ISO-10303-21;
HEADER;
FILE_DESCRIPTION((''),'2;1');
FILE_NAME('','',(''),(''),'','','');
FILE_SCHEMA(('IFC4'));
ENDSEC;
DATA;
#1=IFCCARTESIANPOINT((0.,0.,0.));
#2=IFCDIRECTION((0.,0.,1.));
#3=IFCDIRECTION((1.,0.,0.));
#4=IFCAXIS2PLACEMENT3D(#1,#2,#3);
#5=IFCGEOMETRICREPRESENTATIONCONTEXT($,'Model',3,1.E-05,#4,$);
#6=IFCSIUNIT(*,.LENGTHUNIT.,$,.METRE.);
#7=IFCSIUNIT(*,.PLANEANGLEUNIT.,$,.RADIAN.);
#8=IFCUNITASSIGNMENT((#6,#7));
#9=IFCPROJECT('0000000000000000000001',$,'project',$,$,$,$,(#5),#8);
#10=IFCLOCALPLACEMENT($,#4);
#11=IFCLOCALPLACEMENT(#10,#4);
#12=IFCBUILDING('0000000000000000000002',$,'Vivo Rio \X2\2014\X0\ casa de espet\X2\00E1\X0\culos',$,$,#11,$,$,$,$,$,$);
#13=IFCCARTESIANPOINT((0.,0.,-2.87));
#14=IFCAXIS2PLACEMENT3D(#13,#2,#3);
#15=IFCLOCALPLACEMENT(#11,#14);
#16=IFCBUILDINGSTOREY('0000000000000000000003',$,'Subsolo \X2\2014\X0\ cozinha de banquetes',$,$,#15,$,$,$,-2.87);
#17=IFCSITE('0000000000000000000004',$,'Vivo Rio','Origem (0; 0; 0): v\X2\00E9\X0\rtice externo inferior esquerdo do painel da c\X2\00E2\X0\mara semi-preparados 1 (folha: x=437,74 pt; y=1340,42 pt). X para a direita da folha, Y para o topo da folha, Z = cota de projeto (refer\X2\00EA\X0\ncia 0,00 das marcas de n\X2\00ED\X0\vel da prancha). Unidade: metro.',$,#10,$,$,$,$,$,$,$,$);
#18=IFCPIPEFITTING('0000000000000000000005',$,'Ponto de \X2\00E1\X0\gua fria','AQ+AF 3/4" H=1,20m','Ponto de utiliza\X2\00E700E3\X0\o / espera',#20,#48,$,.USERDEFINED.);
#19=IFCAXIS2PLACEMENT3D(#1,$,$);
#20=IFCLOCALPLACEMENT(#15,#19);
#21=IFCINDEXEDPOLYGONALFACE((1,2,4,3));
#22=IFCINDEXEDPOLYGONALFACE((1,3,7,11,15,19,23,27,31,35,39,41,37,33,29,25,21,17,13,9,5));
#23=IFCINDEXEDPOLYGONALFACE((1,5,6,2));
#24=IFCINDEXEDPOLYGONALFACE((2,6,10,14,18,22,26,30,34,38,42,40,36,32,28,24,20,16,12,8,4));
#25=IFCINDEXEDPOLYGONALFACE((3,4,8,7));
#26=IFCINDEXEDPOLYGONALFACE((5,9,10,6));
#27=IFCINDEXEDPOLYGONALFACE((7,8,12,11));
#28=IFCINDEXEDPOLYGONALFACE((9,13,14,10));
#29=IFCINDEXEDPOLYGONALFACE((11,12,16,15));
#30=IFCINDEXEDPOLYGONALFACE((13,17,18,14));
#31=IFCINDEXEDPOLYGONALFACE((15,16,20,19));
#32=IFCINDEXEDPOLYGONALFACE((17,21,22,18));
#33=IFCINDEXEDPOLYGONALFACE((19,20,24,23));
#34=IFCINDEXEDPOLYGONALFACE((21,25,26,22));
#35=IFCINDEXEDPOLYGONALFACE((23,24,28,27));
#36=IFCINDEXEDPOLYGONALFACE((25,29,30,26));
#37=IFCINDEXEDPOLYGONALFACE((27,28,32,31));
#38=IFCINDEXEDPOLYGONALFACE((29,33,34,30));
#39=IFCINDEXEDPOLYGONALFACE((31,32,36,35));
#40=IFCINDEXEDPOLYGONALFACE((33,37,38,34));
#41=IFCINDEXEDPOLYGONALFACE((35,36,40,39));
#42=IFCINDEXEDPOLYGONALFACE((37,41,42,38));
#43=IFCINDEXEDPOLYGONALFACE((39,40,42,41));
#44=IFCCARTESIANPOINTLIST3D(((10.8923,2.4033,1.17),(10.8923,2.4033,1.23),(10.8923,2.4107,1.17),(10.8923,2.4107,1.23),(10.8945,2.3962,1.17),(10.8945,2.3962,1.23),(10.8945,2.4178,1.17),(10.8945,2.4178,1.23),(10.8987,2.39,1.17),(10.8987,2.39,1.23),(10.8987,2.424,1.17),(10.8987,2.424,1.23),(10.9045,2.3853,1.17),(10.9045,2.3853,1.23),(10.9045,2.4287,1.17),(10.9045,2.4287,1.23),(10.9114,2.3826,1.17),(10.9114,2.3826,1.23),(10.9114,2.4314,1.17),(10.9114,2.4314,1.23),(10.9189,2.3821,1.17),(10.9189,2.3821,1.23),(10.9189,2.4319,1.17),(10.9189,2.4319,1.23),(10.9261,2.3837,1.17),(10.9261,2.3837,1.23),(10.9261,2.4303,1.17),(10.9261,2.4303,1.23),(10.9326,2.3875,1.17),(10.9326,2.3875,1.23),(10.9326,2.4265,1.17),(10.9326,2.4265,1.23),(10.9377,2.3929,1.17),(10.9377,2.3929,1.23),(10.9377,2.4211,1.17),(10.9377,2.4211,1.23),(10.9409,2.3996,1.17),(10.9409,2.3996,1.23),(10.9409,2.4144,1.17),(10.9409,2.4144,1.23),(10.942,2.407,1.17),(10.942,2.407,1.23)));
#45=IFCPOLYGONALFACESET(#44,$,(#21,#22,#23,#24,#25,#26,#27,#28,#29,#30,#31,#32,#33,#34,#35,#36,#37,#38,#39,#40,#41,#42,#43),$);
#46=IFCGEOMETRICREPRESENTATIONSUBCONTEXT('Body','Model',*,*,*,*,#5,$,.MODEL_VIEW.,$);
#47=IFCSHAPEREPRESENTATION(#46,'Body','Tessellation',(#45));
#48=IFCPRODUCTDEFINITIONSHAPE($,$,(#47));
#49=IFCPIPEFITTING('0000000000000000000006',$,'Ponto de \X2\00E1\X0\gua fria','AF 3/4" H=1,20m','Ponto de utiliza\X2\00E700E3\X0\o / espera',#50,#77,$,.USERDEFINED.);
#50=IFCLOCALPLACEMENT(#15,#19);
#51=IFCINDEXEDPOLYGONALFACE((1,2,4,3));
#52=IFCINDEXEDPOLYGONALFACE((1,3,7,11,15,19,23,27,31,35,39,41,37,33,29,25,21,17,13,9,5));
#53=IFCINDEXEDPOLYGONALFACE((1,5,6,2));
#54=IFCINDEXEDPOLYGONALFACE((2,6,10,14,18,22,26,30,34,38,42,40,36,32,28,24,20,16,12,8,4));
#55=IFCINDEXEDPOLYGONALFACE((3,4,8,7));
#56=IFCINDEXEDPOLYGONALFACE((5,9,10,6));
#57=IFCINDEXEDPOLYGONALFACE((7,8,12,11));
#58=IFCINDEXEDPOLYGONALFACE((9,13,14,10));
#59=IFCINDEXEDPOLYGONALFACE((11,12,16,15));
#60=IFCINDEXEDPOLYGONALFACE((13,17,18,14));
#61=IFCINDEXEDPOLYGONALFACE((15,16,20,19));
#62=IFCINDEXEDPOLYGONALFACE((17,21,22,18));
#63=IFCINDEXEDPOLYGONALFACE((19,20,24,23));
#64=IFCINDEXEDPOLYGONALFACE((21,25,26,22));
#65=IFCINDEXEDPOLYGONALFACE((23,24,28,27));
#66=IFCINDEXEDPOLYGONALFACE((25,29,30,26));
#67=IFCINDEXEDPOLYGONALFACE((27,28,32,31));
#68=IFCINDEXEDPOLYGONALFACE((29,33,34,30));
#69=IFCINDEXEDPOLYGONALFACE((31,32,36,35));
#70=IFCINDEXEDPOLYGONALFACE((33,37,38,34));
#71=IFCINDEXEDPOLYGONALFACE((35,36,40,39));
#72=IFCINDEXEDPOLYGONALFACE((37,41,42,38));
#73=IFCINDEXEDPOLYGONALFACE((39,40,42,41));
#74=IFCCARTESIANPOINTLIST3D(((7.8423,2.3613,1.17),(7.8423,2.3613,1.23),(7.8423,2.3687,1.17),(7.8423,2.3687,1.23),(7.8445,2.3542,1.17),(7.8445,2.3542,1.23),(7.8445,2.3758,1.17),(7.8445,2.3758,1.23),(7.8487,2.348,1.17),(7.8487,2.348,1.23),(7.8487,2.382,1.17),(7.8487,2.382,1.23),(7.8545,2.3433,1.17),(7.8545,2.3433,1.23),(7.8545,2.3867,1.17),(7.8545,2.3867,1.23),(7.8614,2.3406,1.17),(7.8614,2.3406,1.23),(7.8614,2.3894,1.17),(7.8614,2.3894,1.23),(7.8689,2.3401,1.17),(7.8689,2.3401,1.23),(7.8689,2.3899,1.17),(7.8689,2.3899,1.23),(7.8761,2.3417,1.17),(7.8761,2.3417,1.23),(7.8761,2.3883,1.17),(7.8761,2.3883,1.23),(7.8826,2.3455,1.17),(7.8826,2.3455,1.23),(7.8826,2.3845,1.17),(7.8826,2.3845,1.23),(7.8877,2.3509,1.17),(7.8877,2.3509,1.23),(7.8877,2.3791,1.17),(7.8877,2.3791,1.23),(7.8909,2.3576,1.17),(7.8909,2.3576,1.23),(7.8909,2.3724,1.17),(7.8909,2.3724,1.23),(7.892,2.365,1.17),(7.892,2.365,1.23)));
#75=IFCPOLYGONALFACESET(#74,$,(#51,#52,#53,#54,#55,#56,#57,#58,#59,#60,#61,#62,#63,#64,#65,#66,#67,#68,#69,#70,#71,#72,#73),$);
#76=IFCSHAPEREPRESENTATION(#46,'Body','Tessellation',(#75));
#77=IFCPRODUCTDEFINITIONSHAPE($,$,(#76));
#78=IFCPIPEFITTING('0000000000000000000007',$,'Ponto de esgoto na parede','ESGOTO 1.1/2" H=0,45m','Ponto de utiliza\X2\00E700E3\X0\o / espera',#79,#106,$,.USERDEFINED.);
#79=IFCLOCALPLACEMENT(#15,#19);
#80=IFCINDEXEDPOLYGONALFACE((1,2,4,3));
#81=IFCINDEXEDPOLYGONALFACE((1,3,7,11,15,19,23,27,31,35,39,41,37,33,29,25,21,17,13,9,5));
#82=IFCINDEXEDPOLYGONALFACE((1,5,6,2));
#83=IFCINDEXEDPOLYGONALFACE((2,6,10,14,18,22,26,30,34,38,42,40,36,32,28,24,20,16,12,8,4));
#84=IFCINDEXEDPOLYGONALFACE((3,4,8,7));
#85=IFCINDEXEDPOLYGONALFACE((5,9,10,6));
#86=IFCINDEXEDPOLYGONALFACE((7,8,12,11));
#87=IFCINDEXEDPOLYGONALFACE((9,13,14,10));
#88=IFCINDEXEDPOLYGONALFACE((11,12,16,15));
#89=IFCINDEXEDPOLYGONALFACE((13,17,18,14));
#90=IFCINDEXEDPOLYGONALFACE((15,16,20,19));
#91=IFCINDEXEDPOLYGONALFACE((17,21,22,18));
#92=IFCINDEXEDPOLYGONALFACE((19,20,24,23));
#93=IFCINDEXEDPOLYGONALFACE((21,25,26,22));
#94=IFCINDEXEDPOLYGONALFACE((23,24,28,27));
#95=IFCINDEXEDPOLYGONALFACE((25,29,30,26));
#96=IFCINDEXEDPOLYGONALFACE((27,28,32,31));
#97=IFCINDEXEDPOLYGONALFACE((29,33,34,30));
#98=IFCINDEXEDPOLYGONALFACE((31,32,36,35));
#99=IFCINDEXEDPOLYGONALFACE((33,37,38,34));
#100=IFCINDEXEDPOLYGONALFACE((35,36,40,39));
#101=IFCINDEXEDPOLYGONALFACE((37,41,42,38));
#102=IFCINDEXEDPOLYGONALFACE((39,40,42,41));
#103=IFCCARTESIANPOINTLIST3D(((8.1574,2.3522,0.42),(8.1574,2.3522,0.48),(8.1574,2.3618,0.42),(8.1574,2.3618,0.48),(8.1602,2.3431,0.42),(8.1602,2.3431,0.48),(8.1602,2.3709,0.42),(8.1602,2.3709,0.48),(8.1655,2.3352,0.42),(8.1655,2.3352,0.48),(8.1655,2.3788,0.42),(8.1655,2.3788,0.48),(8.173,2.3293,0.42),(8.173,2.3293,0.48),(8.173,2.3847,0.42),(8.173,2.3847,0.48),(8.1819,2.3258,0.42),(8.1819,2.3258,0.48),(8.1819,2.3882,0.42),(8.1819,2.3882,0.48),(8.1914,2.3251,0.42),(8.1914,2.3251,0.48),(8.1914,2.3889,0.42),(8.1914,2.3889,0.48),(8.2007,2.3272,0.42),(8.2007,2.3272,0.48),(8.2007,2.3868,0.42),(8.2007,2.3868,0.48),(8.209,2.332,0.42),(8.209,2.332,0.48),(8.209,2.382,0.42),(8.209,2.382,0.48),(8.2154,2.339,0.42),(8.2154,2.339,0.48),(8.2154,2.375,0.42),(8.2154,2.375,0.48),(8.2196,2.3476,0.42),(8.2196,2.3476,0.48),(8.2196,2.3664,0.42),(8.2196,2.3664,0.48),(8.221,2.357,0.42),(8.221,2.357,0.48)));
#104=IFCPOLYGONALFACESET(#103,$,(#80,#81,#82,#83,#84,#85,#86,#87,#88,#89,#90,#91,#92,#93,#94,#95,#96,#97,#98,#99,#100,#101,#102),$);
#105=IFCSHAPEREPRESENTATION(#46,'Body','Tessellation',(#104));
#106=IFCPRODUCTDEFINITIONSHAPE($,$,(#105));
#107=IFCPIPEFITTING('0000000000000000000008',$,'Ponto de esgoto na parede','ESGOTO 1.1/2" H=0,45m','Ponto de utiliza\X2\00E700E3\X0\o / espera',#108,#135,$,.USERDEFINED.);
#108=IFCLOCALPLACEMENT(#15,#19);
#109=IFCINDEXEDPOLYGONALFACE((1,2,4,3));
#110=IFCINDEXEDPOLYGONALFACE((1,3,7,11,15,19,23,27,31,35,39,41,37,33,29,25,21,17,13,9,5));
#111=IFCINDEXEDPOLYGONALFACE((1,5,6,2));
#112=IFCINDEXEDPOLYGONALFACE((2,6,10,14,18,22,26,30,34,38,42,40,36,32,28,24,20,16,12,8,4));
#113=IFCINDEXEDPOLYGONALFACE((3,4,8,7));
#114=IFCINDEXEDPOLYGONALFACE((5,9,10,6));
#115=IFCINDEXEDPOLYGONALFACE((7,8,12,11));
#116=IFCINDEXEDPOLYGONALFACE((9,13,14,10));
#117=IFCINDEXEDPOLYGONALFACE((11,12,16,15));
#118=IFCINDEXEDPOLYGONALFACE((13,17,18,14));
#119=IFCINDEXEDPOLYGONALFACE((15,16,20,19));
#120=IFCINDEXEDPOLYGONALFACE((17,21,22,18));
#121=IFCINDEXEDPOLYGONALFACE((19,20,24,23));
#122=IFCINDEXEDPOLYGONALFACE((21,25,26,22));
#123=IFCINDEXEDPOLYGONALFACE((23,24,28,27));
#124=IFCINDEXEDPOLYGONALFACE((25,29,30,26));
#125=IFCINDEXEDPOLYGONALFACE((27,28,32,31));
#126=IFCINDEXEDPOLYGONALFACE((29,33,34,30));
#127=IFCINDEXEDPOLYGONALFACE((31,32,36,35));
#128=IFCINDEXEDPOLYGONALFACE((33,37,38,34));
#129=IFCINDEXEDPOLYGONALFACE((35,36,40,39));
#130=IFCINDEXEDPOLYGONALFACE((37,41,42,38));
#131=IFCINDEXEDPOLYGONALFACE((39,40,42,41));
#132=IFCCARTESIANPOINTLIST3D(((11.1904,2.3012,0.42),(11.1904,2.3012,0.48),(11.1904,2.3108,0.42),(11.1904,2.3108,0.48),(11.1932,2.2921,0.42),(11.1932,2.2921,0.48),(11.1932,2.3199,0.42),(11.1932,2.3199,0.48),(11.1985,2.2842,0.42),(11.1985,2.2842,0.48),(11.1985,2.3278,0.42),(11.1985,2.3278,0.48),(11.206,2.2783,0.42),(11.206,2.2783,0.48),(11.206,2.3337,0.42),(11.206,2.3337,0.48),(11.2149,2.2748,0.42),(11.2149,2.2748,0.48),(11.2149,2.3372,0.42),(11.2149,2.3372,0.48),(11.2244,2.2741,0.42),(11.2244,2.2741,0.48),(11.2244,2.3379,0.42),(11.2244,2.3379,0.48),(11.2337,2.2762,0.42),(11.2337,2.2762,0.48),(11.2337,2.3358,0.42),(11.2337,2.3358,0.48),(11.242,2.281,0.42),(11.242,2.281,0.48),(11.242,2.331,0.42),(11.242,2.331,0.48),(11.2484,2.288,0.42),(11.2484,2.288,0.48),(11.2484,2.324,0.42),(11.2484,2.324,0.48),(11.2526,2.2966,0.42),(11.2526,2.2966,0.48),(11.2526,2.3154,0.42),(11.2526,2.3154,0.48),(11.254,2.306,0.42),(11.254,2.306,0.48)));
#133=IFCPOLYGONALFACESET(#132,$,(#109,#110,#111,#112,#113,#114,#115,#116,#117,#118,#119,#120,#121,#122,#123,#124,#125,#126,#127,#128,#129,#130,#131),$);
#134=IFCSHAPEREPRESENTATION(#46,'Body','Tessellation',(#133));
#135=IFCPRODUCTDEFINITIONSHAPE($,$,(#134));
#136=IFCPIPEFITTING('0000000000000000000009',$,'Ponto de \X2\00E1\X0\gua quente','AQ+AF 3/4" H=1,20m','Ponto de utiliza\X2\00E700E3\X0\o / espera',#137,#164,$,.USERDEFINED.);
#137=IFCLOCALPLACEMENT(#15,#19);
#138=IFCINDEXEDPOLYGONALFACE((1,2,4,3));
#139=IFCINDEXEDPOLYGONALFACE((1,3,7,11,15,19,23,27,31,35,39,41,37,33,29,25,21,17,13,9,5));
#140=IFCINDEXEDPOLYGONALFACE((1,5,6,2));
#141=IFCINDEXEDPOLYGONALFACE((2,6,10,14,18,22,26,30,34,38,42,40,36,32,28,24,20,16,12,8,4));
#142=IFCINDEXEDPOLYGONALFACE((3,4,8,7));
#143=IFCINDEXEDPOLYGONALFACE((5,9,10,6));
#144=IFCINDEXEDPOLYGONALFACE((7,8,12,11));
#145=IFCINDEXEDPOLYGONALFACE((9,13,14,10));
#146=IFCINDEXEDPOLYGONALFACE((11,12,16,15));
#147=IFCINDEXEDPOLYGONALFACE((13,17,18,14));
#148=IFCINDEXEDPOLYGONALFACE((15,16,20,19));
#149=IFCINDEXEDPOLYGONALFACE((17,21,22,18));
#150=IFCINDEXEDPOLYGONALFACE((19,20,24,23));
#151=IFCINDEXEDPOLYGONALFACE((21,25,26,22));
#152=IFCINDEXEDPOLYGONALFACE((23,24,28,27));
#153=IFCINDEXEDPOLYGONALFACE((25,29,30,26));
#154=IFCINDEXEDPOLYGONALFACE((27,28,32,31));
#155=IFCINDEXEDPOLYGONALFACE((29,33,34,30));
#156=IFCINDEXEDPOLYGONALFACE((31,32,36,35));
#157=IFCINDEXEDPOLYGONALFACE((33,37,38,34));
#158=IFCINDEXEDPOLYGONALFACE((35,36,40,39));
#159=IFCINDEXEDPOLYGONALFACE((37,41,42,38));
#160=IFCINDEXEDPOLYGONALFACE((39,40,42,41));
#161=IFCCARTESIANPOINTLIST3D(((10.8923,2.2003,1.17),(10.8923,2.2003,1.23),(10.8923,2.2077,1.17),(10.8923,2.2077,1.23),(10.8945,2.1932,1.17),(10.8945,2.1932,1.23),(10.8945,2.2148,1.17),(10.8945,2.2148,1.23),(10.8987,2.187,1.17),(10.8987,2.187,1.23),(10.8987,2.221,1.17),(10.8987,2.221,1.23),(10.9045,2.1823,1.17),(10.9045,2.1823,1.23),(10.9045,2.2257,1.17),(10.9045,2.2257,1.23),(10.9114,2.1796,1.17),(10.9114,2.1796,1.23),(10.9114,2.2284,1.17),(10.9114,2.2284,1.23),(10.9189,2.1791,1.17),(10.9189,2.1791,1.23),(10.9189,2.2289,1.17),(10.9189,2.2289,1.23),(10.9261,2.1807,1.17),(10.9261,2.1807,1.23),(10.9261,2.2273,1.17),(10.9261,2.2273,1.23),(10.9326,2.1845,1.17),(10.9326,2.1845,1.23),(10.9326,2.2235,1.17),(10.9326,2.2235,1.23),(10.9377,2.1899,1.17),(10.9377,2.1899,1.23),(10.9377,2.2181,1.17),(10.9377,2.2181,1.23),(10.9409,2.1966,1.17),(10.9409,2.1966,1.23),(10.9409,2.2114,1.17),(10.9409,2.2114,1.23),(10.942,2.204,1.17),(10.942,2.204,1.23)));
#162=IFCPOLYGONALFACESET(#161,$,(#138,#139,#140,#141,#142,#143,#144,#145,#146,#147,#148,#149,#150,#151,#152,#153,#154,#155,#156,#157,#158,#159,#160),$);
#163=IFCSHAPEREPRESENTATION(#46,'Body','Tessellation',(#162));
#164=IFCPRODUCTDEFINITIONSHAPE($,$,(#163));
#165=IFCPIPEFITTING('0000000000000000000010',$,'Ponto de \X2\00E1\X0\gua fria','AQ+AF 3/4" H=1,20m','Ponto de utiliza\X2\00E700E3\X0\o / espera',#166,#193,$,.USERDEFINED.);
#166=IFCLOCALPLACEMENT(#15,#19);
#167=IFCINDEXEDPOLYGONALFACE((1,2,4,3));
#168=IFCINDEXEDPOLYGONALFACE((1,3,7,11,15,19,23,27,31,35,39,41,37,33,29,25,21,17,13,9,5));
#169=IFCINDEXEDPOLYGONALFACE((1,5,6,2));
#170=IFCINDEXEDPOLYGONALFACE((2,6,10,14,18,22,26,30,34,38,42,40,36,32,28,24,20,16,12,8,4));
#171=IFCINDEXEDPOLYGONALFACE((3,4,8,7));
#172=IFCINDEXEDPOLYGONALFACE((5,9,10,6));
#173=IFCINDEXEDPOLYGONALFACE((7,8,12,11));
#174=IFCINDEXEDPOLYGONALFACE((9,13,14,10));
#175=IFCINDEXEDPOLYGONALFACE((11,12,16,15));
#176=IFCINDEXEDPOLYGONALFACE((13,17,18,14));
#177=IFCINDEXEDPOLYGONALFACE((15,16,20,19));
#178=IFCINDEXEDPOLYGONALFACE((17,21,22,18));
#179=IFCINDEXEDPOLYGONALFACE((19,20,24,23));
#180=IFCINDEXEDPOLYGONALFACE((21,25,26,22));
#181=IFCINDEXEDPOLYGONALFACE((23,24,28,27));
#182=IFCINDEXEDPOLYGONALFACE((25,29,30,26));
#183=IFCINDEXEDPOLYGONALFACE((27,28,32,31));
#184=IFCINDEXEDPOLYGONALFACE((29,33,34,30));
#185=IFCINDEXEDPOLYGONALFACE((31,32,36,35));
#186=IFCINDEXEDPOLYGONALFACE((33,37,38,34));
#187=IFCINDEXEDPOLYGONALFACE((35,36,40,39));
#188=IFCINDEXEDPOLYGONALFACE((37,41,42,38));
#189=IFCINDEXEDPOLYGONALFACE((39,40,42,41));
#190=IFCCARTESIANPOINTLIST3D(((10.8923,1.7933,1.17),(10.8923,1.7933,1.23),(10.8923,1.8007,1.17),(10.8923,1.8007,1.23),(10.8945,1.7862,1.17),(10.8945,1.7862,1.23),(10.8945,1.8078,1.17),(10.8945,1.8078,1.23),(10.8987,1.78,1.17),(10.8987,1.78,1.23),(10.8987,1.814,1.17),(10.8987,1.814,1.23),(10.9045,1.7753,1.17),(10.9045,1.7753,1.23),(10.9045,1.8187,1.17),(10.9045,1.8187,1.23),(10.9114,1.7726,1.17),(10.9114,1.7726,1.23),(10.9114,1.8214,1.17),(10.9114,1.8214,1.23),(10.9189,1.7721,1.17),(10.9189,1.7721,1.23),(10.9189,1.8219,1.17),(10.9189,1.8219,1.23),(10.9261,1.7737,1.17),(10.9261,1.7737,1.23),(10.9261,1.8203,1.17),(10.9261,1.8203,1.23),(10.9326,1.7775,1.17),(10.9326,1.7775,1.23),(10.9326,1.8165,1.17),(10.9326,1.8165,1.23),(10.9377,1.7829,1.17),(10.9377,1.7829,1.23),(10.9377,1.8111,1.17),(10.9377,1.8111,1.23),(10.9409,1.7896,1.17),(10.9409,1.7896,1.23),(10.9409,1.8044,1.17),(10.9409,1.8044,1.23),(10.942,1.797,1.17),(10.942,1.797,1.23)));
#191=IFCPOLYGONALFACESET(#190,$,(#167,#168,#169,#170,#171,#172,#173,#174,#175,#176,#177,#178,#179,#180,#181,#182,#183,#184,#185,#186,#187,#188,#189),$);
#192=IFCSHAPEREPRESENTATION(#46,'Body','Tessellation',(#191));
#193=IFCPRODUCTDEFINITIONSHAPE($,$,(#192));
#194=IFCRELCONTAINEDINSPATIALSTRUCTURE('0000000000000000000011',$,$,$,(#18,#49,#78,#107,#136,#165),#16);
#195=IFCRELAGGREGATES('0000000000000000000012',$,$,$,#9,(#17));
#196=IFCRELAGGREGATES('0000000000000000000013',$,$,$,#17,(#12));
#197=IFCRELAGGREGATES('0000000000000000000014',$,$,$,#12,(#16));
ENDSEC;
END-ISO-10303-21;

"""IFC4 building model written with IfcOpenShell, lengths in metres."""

from ifc_helpers import new_model, si_unit, frame, origin_with_axes, origin_2d, place, context, subcontext, project, spatial, circle, extrude, element, save


model = new_model("IFC4")

# Units and contexts
model_context = context("Model", 3, precision=1e-05, world=origin_with_axes())
body_context = subcontext(model_context, "Body", "Model", "MODEL_VIEW")
ifc_project = project(units=[si_unit("LENGTHUNIT", "METRE"), si_unit("PLANEANGLEUNIT", "RADIAN")], contexts=[model_context])

# Site, building, storey
site_placement = place(None, origin_with_axes())
site = spatial("IfcSite", under=ifc_project, at=site_placement, Name="Vivo Rio", Description="Origem (0; 0; 0): vértice externo inferior esquerdo do painel da câmara semi-preparados 1 (folha: x=437,74 pt; y=1340,42 pt). X para a direita da folha, Y para o topo da folha, Z = cota de projeto (referência 0,00 das marcas de nível da prancha). Unidade: metro.")
building_placement = place(site_placement, origin_with_axes())
building = spatial("IfcBuilding", under=site, at=building_placement, Name="Vivo Rio — casa de espetáculos")
storey_placement = place(building_placement, frame((0.0, 0.0, -2.87), z_axis=(0.0, 0.0, 1.0), x_axis=(1.0, 0.0, 0.0)))
storey = spatial("IfcBuildingStorey", under=building, at=storey_placement, Name="Subsolo — cozinha de banquetes", Elevation=-2.87)

# Pipe fittings
pipe_fitting_1_placement = place(storey_placement, origin_with_axes())
element("IfcPipeFitting", 1, at=pipe_fitting_1_placement, inside=storey, Name="Ponto de água fria", Description="AQ+AF 3/4\" H=1,20m", ObjectType="Ponto de utilização / espera", PredefinedType="USERDEFINED", context=body_context, shape_type="SweptSolid", body=[
    extrude(circle(Radius=0.025, at=origin_2d()), frame((10.917, 2.407, 1.17), z_axis=(0.0, 0.0, 1.0), x_axis=(1.0, 0.0, 0.0)), (0.0, 0.0, 1.0), 0.06),
])
pipe_fitting_2_placement = place(storey_placement, origin_with_axes())
element("IfcPipeFitting", 2, at=pipe_fitting_2_placement, inside=storey, Name="Ponto de água fria", Description="AF 3/4\" H=1,20m", ObjectType="Ponto de utilização / espera", PredefinedType="USERDEFINED", context=body_context, shape_type="SweptSolid", body=[
    extrude(circle(Radius=0.025, at=origin_2d()), frame((7.867, 2.365, 1.17), z_axis=(0.0, 0.0, 1.0), x_axis=(1.0, 0.0, 0.0)), (0.0, 0.0, 1.0), 0.06),
])
pipe_fitting_3_placement = place(storey_placement, origin_with_axes())
element("IfcPipeFitting", 3, at=pipe_fitting_3_placement, inside=storey, Name="Ponto de esgoto na parede", Description="ESGOTO 1.1/2\" H=0,45m", ObjectType="Ponto de utilização / espera", PredefinedType="USERDEFINED", context=body_context, shape_type="SweptSolid", body=[
    extrude(circle(Radius=0.032, at=origin_2d()), frame((8.189, 2.357, 0.42), z_axis=(0.0, 0.0, 1.0), x_axis=(1.0, 0.0, 0.0)), (0.0, 0.0, 1.0), 0.06),
])
pipe_fitting_4_placement = place(storey_placement, origin_with_axes())
element("IfcPipeFitting", 4, at=pipe_fitting_4_placement, inside=storey, Name="Ponto de esgoto na parede", Description="ESGOTO 1.1/2\" H=0,45m", ObjectType="Ponto de utilização / espera", PredefinedType="USERDEFINED", context=body_context, shape_type="SweptSolid", body=[
    extrude(circle(Radius=0.032, at=origin_2d()), frame((11.222, 2.306, 0.42), z_axis=(0.0, 0.0, 1.0), x_axis=(1.0, 0.0, 0.0)), (0.0, 0.0, 1.0), 0.06),
])
pipe_fitting_5_placement = place(storey_placement, origin_with_axes())
element("IfcPipeFitting", 5, at=pipe_fitting_5_placement, inside=storey, Name="Ponto de água quente", Description="AQ+AF 3/4\" H=1,20m", ObjectType="Ponto de utilização / espera", PredefinedType="USERDEFINED", context=body_context, shape_type="SweptSolid", body=[
    extrude(circle(Radius=0.025, at=origin_2d()), frame((10.917, 2.204, 1.17), z_axis=(0.0, 0.0, 1.0), x_axis=(1.0, 0.0, 0.0)), (0.0, 0.0, 1.0), 0.06),
])
pipe_fitting_6_placement = place(storey_placement, origin_with_axes())
element("IfcPipeFitting", 6, at=pipe_fitting_6_placement, inside=storey, Name="Ponto de água fria", Description="AQ+AF 3/4\" H=1,20m", ObjectType="Ponto de utilização / espera", PredefinedType="USERDEFINED", context=body_context, shape_type="SweptSolid", body=[
    extrude(circle(Radius=0.025, at=origin_2d()), frame((10.917, 1.797, 1.17), z_axis=(0.0, 0.0, 1.0), x_axis=(1.0, 0.0, 0.0)), (0.0, 0.0, 1.0), 0.06),
])

save(model, "model.ifc")
